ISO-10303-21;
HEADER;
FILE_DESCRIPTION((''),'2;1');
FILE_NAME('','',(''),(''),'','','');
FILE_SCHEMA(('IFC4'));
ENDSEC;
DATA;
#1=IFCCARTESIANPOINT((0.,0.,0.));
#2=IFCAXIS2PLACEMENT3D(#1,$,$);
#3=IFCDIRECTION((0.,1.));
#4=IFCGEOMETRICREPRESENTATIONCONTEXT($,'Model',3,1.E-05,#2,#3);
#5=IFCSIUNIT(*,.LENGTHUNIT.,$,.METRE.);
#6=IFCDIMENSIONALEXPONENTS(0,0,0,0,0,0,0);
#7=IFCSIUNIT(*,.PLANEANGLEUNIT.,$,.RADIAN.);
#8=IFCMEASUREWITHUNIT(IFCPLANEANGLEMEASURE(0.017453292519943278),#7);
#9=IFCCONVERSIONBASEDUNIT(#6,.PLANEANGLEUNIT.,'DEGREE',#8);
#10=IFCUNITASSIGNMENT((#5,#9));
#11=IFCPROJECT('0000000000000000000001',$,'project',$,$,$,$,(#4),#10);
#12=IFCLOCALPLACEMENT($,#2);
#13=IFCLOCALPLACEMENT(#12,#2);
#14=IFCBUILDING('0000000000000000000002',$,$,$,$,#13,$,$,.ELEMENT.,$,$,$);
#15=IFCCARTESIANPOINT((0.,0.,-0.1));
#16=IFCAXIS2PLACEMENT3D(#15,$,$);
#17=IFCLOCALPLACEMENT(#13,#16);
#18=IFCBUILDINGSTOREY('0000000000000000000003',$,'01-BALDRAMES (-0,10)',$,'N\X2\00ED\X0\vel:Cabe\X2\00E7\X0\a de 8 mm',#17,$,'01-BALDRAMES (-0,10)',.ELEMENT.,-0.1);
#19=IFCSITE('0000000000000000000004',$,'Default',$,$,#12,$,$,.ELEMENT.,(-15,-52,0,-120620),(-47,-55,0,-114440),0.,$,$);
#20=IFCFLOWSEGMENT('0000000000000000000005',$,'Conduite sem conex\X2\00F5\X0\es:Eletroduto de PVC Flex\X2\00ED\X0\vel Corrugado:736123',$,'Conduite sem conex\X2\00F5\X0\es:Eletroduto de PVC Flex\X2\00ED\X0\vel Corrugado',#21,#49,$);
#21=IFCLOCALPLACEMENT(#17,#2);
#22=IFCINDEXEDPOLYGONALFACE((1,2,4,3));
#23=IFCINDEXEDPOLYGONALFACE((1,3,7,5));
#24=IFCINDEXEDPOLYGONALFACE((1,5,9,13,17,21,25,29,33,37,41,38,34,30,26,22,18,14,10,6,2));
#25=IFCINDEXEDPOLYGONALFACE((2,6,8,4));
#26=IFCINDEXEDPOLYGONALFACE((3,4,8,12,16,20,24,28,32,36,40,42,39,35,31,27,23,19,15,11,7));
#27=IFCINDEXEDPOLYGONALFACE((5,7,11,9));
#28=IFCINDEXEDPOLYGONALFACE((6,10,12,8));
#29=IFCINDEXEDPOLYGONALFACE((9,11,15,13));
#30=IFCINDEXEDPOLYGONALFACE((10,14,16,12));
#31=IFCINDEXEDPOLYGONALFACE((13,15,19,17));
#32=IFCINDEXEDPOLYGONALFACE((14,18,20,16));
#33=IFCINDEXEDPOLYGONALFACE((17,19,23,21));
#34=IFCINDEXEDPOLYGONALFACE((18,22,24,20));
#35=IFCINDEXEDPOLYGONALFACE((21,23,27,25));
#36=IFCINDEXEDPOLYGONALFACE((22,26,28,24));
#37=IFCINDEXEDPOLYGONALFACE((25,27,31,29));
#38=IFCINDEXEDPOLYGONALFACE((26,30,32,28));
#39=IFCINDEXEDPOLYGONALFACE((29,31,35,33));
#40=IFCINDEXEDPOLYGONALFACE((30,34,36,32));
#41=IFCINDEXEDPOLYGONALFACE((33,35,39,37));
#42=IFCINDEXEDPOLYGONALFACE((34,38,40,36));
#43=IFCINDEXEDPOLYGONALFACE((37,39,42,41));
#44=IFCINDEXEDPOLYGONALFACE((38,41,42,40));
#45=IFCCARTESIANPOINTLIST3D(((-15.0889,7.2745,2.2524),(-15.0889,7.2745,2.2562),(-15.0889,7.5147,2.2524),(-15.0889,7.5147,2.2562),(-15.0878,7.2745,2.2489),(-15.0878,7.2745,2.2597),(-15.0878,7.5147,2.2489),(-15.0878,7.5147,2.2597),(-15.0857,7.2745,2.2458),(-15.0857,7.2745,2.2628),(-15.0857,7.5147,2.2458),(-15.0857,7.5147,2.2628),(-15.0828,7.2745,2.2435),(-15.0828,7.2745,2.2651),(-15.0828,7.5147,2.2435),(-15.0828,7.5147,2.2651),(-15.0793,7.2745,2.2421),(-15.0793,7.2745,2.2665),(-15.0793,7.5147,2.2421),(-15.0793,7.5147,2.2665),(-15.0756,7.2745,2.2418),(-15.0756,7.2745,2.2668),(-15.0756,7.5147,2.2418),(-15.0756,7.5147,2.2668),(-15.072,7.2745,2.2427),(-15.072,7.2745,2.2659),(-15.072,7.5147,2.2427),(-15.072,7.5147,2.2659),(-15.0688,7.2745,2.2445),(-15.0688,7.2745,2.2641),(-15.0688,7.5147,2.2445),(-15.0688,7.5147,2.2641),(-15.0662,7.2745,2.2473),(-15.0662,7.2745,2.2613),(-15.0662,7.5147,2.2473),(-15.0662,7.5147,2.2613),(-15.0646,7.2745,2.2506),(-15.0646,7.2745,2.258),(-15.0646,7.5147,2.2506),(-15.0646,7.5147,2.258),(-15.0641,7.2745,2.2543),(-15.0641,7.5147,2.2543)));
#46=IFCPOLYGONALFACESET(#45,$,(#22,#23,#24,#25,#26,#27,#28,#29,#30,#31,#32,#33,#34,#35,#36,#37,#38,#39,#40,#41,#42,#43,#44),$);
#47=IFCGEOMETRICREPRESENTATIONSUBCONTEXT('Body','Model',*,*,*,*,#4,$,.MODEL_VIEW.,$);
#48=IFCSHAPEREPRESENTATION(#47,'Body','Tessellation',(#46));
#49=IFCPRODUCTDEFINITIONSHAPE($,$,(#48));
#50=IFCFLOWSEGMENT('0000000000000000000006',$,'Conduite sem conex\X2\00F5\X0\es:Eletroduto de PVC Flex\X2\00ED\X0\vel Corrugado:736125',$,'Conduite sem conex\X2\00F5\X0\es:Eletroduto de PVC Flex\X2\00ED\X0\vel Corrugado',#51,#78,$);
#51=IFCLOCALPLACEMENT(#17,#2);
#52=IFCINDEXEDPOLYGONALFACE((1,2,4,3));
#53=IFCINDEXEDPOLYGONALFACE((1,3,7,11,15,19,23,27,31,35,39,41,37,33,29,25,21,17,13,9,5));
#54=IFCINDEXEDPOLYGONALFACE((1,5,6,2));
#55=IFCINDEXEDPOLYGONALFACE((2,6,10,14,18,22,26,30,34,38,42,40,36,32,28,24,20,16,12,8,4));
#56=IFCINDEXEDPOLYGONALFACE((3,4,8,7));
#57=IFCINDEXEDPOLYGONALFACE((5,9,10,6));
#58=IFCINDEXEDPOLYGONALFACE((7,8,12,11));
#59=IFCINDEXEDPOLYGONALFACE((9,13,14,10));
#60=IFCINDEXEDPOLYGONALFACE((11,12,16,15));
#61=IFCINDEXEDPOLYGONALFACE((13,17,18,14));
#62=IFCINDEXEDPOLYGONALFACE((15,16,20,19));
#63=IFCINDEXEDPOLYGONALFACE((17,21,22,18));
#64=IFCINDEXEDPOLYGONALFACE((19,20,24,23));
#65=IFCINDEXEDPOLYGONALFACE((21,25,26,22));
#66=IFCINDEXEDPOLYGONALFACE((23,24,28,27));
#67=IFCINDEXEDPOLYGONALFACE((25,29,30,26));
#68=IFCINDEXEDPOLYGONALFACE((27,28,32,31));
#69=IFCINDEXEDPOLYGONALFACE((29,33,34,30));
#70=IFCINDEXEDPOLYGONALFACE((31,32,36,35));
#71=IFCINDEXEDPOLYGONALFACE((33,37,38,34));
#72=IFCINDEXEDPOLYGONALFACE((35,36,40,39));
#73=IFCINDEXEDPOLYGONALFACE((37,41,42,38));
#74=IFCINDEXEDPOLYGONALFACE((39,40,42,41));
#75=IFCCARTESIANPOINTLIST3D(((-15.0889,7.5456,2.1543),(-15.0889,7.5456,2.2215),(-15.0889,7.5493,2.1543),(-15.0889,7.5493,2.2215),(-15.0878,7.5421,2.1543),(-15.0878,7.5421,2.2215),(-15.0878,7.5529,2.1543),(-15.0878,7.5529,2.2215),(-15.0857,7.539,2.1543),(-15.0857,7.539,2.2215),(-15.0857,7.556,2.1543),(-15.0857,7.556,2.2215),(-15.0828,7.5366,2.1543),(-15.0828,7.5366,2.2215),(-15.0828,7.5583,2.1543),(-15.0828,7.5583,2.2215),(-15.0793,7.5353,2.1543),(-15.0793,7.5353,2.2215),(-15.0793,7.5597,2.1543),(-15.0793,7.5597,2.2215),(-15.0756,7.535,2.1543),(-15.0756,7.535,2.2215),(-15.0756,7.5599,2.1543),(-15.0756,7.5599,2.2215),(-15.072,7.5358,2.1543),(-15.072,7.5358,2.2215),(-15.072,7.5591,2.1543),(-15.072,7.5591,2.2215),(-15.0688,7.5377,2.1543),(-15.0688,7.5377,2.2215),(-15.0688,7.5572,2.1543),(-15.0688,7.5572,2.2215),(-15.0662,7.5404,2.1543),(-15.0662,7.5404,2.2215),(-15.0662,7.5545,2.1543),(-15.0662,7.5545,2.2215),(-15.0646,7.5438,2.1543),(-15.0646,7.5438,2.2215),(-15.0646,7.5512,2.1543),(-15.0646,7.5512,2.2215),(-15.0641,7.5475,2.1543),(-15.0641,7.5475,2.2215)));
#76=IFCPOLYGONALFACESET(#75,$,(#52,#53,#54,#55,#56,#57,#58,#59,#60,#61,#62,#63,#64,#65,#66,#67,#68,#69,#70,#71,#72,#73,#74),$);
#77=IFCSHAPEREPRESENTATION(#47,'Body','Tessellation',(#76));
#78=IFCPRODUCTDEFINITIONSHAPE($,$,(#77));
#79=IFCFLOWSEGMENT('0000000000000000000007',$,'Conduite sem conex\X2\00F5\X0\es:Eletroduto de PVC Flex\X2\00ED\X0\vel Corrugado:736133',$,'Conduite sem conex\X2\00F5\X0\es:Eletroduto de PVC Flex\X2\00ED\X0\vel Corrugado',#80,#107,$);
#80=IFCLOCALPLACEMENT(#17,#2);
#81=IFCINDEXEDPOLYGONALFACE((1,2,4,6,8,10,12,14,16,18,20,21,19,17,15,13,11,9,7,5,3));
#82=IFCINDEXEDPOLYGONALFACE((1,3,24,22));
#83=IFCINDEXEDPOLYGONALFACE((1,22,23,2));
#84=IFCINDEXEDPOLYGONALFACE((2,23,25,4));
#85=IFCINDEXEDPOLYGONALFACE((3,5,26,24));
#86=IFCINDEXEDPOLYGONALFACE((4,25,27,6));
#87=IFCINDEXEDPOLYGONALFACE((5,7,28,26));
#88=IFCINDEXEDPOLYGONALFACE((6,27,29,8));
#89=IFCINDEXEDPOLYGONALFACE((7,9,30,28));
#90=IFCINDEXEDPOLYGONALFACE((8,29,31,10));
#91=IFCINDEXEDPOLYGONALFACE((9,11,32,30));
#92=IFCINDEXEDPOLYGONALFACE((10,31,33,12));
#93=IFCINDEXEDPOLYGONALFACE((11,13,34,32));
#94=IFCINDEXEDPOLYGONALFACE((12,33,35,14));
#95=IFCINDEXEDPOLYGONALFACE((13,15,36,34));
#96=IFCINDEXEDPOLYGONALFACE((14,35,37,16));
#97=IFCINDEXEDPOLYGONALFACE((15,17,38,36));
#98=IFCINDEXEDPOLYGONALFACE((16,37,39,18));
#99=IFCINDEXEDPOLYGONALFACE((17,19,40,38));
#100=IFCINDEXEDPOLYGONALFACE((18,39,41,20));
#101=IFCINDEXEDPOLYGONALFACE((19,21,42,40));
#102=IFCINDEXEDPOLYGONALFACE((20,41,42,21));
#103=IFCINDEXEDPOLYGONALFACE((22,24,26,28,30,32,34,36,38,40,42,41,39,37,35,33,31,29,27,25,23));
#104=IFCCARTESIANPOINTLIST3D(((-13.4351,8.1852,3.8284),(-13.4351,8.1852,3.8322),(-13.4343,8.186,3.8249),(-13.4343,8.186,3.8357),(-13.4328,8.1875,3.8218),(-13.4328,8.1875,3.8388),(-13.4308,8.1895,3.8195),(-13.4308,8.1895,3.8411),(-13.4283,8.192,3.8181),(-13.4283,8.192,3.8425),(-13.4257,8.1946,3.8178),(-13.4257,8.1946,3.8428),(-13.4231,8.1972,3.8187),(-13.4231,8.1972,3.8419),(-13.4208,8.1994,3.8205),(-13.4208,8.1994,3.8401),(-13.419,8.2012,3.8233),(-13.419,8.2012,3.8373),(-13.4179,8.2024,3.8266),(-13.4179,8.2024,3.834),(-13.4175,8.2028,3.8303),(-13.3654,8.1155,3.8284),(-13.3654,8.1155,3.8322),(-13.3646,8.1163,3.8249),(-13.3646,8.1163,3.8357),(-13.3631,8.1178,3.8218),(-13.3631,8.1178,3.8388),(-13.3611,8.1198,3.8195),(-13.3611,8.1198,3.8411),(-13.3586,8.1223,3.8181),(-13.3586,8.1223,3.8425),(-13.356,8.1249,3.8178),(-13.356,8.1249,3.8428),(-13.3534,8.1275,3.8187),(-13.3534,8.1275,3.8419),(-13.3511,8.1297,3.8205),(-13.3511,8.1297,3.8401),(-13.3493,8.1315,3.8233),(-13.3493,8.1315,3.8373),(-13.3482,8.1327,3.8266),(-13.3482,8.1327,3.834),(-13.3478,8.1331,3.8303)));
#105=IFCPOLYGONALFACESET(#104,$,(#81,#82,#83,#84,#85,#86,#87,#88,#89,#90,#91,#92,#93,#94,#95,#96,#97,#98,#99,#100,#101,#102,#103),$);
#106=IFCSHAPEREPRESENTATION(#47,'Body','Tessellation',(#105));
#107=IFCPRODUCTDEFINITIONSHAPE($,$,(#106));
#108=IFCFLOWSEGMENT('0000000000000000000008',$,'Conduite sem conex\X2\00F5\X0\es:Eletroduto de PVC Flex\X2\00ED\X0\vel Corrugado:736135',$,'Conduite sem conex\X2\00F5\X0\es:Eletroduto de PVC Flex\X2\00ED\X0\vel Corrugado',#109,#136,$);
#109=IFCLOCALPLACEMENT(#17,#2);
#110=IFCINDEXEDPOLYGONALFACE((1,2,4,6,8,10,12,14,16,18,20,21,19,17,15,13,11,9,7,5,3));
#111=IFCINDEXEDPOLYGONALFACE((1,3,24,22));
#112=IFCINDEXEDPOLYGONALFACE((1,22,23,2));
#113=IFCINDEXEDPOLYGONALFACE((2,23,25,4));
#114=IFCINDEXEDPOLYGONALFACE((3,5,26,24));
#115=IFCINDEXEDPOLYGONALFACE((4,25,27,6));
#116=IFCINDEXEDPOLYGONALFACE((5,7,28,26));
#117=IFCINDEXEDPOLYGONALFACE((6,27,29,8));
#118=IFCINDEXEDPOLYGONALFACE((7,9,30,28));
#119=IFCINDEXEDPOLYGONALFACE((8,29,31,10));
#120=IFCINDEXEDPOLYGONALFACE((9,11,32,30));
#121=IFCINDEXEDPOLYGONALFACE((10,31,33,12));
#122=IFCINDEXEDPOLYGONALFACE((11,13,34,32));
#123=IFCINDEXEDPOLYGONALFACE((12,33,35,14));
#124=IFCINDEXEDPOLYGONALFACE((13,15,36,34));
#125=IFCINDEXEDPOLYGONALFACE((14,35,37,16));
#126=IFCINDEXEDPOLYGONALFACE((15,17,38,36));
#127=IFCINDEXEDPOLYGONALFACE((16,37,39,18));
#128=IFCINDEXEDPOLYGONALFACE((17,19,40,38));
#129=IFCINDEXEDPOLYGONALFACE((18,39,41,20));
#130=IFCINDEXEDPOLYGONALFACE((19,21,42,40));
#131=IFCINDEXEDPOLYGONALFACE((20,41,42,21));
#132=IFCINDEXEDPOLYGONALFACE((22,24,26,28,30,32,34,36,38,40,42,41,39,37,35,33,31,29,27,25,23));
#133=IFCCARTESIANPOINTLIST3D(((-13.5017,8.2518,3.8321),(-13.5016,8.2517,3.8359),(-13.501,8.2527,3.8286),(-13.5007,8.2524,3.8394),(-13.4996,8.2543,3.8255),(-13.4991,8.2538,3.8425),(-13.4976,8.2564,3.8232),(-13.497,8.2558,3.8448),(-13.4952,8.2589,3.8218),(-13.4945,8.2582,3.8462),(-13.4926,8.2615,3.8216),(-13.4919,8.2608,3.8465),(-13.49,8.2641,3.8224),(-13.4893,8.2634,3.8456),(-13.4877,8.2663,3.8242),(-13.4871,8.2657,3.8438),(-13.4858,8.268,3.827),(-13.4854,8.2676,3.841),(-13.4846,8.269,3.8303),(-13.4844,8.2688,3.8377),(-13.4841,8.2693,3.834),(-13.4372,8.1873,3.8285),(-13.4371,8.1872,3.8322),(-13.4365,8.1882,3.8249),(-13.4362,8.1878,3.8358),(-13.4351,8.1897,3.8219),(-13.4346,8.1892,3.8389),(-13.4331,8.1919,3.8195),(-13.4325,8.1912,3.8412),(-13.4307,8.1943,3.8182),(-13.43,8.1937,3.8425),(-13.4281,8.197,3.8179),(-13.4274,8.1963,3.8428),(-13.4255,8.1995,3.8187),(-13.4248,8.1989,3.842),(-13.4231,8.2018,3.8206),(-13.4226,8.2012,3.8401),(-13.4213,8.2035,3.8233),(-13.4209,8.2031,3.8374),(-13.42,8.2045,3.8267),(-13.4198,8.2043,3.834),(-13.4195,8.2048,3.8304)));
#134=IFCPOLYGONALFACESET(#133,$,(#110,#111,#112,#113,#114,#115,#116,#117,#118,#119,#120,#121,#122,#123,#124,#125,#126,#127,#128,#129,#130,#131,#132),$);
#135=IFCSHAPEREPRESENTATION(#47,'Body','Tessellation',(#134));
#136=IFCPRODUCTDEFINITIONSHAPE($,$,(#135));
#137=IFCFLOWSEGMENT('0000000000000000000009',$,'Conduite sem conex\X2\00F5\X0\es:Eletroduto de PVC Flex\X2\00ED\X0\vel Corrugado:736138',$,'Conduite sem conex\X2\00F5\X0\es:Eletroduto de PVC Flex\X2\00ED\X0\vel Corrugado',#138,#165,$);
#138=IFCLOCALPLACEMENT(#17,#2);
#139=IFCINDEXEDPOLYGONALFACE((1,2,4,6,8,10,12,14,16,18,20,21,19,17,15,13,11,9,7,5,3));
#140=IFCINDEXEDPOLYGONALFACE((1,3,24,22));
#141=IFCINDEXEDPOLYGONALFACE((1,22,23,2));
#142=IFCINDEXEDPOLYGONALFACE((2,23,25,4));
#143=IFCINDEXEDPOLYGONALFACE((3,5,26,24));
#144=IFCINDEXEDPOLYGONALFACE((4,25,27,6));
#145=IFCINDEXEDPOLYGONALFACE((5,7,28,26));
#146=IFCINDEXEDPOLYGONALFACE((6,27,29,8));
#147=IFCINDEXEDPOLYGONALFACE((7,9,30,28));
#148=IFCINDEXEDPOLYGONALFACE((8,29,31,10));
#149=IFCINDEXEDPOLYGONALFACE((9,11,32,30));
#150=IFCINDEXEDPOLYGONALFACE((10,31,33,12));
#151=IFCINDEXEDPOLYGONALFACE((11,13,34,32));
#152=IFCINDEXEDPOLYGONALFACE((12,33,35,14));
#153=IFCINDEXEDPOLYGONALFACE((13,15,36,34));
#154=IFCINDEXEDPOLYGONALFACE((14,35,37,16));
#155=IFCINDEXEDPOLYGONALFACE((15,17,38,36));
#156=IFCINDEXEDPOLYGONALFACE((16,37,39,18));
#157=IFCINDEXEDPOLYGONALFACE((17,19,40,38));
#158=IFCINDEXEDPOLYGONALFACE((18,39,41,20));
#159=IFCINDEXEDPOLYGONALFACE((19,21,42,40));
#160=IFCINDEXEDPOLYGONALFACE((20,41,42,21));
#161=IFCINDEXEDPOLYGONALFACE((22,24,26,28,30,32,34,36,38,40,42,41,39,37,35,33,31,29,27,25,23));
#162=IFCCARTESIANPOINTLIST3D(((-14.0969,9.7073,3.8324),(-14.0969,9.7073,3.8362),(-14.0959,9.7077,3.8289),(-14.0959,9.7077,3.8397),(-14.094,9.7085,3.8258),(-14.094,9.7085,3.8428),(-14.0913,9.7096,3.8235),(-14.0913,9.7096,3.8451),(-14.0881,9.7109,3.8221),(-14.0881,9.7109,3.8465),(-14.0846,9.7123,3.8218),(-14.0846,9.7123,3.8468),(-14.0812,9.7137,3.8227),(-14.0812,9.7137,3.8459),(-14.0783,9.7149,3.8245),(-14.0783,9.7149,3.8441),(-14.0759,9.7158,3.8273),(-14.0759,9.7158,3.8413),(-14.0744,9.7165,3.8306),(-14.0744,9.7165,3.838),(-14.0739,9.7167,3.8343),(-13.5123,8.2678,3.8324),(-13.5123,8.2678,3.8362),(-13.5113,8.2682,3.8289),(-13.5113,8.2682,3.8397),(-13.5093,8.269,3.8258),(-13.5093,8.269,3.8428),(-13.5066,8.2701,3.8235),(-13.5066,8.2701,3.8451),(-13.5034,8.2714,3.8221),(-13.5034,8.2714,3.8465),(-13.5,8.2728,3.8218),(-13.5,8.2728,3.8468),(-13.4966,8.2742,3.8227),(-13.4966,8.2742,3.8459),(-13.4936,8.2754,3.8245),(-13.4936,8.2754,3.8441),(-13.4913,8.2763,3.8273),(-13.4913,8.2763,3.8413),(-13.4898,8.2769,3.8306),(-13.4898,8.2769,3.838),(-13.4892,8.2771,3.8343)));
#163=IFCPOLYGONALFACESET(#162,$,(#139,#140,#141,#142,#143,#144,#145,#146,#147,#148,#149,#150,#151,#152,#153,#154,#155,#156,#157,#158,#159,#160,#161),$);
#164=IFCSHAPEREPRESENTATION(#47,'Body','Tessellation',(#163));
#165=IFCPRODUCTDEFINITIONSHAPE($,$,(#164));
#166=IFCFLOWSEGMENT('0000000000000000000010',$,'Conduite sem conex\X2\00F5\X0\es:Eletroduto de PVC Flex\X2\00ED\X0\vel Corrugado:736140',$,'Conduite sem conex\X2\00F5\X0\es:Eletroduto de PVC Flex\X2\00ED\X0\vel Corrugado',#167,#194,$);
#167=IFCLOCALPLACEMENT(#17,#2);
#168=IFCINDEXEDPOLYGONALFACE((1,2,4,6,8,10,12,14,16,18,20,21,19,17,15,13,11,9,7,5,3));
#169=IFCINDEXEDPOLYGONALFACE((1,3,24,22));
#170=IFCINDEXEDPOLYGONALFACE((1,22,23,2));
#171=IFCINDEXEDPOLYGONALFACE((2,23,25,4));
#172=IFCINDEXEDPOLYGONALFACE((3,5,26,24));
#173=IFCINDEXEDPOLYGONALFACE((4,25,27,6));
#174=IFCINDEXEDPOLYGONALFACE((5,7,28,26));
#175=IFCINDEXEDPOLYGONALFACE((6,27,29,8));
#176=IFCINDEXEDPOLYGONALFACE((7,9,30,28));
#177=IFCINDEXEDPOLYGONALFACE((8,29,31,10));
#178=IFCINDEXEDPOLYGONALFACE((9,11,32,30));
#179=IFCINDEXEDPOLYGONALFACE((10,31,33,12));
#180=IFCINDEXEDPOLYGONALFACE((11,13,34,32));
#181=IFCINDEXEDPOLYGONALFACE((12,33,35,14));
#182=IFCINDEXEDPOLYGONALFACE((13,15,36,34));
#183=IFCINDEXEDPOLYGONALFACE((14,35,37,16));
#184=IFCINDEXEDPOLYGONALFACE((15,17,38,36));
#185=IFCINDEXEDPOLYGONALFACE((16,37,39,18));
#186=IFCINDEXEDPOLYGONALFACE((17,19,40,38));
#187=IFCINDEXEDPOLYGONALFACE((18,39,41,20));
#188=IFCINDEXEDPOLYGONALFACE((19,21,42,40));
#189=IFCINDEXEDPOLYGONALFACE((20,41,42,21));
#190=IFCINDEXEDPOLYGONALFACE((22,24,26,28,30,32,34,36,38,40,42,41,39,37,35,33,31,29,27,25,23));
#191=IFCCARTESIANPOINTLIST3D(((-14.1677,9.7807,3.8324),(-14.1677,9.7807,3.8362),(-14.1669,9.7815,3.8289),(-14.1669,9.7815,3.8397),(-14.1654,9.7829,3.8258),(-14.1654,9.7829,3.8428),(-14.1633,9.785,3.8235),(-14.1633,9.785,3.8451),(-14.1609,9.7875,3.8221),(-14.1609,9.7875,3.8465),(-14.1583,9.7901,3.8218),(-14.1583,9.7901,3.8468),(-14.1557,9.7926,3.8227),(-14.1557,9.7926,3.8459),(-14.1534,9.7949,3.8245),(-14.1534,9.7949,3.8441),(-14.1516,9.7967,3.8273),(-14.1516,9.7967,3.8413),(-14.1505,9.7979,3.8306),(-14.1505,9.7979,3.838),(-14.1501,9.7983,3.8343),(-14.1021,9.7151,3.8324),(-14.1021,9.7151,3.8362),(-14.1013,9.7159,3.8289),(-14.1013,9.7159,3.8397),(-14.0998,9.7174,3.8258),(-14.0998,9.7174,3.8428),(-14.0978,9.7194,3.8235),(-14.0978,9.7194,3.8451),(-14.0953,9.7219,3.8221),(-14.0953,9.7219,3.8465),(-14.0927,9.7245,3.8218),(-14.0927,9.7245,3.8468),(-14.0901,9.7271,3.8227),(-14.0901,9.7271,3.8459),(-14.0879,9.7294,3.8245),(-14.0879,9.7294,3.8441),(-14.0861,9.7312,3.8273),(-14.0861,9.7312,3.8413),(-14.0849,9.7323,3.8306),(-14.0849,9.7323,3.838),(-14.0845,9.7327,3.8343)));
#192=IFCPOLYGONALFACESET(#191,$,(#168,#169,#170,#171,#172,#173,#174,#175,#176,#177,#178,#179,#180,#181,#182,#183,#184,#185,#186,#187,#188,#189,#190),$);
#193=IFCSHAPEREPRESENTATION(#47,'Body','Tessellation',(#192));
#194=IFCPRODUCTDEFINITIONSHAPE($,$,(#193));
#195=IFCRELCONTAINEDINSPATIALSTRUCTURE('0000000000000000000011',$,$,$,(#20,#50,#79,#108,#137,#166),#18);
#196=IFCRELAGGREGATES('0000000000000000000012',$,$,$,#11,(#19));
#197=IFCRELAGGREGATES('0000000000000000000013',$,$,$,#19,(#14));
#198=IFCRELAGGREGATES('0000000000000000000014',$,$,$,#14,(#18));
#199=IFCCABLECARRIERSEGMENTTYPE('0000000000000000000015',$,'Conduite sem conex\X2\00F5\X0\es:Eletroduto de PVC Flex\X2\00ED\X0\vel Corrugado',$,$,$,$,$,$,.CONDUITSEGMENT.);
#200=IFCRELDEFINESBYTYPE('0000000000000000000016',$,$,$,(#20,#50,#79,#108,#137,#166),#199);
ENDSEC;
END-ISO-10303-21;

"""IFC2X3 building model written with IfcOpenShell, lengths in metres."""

from ifc_helpers import new_model, entity, si_unit, converted_unit, direction, frame, frame_2d, origin, origin_2d_with_axis, place, context, subcontext, project, spatial, circle, extrude, type_object, element, save


model = new_model("IFC2X3")

# Units and contexts
model_context = context("Model", 3, precision=1e-05, world=origin(), true_north=direction((0.0, 1.0)))
body_context = subcontext(model_context, "Body", "Model", "MODEL_VIEW")
ifc_project = project(units=[si_unit("LENGTHUNIT", "METRE"), converted_unit("PLANEANGLEUNIT", "DEGREE", entity("IfcPlaneAngleMeasure", 0.017453292519943278), si_unit("PLANEANGLEUNIT", "RADIAN"), dimensions=[0, 0, 0, 0, 0, 0, 0])], contexts=[model_context])

# Site, building, storey
site_placement = place(None, origin())
site = spatial("IfcSite", under=ifc_project, at=site_placement, Name="Default", CompositionType="ELEMENT", RefLatitude=(-15, -52, 0, -120620), RefLongitude=(-47, -55, 0, -114440), RefElevation=0.0)
building_placement = place(site_placement, origin())
building = spatial("IfcBuilding", under=site, at=building_placement, CompositionType="ELEMENT")
storey_placement = place(building_placement, frame((0.0, 0.0, -0.1)))
storey = spatial("IfcBuildingStorey", under=building, at=storey_placement, Name="01-BALDRAMES (-0,10)", ObjectType="Nível:Cabeça de 8 mm", LongName="01-BALDRAMES (-0,10)", CompositionType="ELEMENT", Elevation=-0.1)

# Flow segments
cable_carrier_segment_type = type_object("IfcCableCarrierSegmentType", Name="Conduite sem conexões:Eletroduto de PVC Flexível Corrugado", PredefinedType="CONDUITSEGMENT")
flow_segment_1_placement = place(storey_placement, origin())
element("IfcFlowSegment", 1, at=flow_segment_1_placement, inside=storey, type_object=cable_carrier_segment_type, Name="Conduite sem conexões:Eletroduto de PVC Flexível Corrugado:736123", ObjectType="Conduite sem conexões:Eletroduto de PVC Flexível Corrugado", context=body_context, shape_type="SweptSolid", body=[
    extrude(circle(Radius=0.0125, at=frame_2d((0.0, 0.0), x_axis=(1.0, 0.0))), frame((-15.0766, 7.2745, 2.2543), z_axis=(0.0, 1.0, 0.0), x_axis=(1.0, 0.0, 0.0)), (0.0, 0.0, 1.0), 0.2402),
])
flow_segment_2_placement = place(storey_placement, origin())
element("IfcFlowSegment", 2, at=flow_segment_2_placement, inside=storey, type_object=cable_carrier_segment_type, Name="Conduite sem conexões:Eletroduto de PVC Flexível Corrugado:736125", ObjectType="Conduite sem conexões:Eletroduto de PVC Flexível Corrugado", context=body_context, shape_type="SweptSolid", body=[
    extrude(circle(Radius=0.0125, at=frame_2d((0.0, 0.0), x_axis=(1.0, 0.0))), frame((-15.0766, 7.5475, 2.1543)), (0.0, 0.0, 1.0), 0.0672),
])
flow_segment_3_placement = place(storey_placement, origin())
element("IfcFlowSegment", 3, at=flow_segment_3_placement, inside=storey, type_object=cable_carrier_segment_type, Name="Conduite sem conexões:Eletroduto de PVC Flexível Corrugado:736133", ObjectType="Conduite sem conexões:Eletroduto de PVC Flexível Corrugado", context=body_context, shape_type="SweptSolid", body=[
    extrude(circle(Radius=0.0125, at=frame_2d((0.0, 0.0), x_axis=(1.0, 0.0))), frame((-13.4263, 8.1939, 3.8303), z_axis=(0.707107, -0.707107, 0.0), x_axis=(0.707107, 0.707107, 0.0)), (0.0, 0.0, 1.0), 0.0986),
])
flow_segment_4_placement = place(storey_placement, origin())
element("IfcFlowSegment", 4, at=flow_segment_4_placement, inside=storey, type_object=cable_carrier_segment_type, Name="Conduite sem conexões:Eletroduto de PVC Flexível Corrugado:736135", ObjectType="Conduite sem conexões:Eletroduto de PVC Flexível Corrugado", context=body_context, shape_type="SweptSolid", body=[
    extrude(circle(Radius=0.0125, at=frame_2d((0.0, 0.0), x_axis=(1.0, 0.0))), frame((-13.4284, 8.196, 3.8304), z_axis=(-0.706542, 0.706542, 0.039968), x_axis=(0.707107, 0.707107, 0.0)), (0.0, 0.0, 1.0), 0.0913),
])
flow_segment_5_placement = place(storey_placement, origin())
element("IfcFlowSegment", 5, at=flow_segment_5_placement, inside=storey, type_object=cable_carrier_segment_type, Name="Conduite sem conexões:Eletroduto de PVC Flexível Corrugado:736138", ObjectType="Conduite sem conexões:Eletroduto de PVC Flexível Corrugado", context=body_context, shape_type="SweptSolid", body=[
    extrude(circle(Radius=0.0125, at=origin_2d_with_axis()), frame((-13.5008, 8.2724, 3.8343), z_axis=(-0.376292, 0.926501, 0.0), x_axis=(0.926501, 0.376292, 0.0)), (0.0, 0.0, 1.0), 1.5537),
])
flow_segment_6_placement = place(storey_placement, origin())
element("IfcFlowSegment", 6, at=flow_segment_6_placement, inside=storey, type_object=cable_carrier_segment_type, Name="Conduite sem conexões:Eletroduto de PVC Flexível Corrugado:736140", ObjectType="Conduite sem conexões:Eletroduto de PVC Flexível Corrugado", context=body_context, shape_type="SweptSolid", body=[
    extrude(circle(Radius=0.0125, at=frame_2d((0.0, 0.0), x_axis=(1.0, 0.0))), frame((-14.1589, 9.7894, 3.8343), z_axis=(0.707107, -0.707107, 0.0), x_axis=(0.707107, 0.707107, 0.0)), (0.0, 0.0, 1.0), 0.0927),
])

save(model, "model.ifc")
